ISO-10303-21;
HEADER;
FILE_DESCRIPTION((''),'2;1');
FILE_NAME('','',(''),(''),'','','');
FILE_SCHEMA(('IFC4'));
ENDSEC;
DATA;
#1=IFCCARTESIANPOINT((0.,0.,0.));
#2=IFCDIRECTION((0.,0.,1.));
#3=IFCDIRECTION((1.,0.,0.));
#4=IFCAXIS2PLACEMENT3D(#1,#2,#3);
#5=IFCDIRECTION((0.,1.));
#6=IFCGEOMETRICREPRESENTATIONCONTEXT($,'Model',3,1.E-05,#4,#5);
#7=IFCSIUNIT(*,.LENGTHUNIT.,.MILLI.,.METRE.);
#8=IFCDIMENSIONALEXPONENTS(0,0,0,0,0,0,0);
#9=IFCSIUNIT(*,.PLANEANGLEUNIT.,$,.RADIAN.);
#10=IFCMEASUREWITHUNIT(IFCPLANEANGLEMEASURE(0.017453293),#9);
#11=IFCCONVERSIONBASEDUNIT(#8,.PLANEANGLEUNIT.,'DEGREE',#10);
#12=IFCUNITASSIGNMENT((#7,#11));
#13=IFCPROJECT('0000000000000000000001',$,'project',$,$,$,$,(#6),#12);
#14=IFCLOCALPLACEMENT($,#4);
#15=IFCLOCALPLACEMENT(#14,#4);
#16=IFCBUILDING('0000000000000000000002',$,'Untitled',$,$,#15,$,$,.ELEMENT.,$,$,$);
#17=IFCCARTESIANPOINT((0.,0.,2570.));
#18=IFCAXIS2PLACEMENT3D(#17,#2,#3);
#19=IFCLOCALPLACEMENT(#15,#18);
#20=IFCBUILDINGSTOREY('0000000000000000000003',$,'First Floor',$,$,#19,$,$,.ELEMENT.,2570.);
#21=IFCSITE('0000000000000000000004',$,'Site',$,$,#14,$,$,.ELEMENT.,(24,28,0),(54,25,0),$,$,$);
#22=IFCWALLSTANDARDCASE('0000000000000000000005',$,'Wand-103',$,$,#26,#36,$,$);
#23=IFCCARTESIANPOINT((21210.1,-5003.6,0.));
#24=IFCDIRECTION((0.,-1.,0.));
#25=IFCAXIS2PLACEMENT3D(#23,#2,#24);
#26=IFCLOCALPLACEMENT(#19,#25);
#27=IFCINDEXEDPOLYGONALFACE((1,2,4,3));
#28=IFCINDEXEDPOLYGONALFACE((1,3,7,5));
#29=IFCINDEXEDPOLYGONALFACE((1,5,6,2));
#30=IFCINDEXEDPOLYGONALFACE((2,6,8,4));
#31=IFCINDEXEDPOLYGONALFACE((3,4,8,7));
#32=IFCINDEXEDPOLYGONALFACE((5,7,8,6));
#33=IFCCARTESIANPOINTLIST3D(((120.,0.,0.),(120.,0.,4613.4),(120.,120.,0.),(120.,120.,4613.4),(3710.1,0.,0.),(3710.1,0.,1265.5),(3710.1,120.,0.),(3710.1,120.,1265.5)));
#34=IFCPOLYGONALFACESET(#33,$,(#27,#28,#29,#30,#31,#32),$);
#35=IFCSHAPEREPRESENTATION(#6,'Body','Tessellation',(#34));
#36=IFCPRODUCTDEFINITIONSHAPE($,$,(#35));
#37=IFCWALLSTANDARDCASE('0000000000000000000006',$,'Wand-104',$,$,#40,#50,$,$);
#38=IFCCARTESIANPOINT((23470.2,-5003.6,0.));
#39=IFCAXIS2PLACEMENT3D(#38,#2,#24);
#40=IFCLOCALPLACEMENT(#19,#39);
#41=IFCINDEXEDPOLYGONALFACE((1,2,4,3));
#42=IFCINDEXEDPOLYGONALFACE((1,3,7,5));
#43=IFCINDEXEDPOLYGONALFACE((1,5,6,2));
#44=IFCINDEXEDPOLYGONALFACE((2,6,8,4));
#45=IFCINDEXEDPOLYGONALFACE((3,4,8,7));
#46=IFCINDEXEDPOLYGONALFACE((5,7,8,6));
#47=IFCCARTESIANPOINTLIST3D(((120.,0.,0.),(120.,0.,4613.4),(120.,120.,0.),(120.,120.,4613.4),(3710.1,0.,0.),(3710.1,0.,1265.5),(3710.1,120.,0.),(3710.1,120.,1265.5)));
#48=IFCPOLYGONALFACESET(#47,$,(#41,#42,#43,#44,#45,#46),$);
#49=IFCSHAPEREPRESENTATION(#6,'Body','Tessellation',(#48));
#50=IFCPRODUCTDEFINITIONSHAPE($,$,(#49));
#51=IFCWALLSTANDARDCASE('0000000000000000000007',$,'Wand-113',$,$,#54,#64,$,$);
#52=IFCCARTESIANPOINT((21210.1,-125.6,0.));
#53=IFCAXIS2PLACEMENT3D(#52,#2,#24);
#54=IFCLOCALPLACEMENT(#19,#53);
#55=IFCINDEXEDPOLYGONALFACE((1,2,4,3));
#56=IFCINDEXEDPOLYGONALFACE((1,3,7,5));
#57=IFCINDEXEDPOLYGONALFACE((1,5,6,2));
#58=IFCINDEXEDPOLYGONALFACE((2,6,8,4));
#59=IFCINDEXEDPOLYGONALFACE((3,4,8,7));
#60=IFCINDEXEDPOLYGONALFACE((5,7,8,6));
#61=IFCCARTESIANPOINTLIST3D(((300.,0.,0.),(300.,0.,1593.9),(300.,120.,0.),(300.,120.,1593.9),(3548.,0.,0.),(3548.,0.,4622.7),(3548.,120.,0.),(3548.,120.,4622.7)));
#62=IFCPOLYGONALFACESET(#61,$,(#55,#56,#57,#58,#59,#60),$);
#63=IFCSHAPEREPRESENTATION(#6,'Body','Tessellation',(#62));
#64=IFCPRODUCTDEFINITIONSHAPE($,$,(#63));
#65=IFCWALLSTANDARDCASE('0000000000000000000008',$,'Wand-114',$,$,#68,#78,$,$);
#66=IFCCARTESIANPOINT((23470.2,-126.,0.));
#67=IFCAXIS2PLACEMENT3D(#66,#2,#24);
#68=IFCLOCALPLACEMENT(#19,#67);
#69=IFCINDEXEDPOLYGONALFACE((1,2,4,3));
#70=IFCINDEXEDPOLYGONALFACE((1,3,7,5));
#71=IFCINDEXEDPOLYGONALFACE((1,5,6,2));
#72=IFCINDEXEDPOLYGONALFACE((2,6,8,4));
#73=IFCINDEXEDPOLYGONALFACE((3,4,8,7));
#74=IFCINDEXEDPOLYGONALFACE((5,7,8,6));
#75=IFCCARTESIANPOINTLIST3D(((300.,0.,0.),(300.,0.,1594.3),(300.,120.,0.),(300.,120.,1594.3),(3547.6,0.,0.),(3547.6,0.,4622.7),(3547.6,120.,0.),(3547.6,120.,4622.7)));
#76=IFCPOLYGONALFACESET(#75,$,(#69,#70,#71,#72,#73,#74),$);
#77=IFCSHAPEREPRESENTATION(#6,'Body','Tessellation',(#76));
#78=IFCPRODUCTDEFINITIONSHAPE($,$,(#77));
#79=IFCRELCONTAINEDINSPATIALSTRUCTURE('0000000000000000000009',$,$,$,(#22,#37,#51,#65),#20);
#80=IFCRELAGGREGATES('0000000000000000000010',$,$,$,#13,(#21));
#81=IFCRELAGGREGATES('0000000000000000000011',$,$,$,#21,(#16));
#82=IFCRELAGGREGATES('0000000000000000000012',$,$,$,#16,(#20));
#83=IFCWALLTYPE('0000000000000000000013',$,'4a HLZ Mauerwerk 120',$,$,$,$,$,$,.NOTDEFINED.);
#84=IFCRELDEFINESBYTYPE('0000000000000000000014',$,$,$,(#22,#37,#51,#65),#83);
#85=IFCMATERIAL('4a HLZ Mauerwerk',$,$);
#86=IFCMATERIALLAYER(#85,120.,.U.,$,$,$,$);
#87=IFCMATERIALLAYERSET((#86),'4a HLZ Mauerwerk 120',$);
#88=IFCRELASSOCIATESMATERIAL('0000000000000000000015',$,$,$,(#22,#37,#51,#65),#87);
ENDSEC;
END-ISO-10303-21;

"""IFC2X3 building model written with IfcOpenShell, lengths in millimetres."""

from ifc_helpers import new_model, entity, si_unit, converted_unit, direction, frame, origin_with_axes, place, context, project, spatial, polyline, outline, extrude, clip, halfspace, material, layer, layer_set, layer_usage, type_object, element, save


model = new_model("IFC2X3")

# Units and contexts
model_context = context("Model", 3, precision=1e-05, world=origin_with_axes(), true_north=direction((0.0, 1.0)))
ifc_project = project(units=[si_unit("LENGTHUNIT", "METRE", prefix="MILLI"), converted_unit("PLANEANGLEUNIT", "DEGREE", entity("IfcPlaneAngleMeasure", 0.017453293), si_unit("PLANEANGLEUNIT", "RADIAN"), dimensions=[0, 0, 0, 0, 0, 0, 0])], contexts=[model_context])

# Site, building, storey
site_placement = place(None, origin_with_axes())
site = spatial("IfcSite", under=ifc_project, at=site_placement, Name="Site", CompositionType="ELEMENT", RefLatitude=(24, 28, 0), RefLongitude=(54, 25, 0))
building_placement = place(site_placement, origin_with_axes())
building = spatial("IfcBuilding", under=site, at=building_placement, Name="Untitled", CompositionType="ELEMENT")
storey_placement = place(building_placement, frame((0.0, 0.0, 2570.0), z_axis=(0.0, 0.0, 1.0), x_axis=(1.0, 0.0, 0.0)))
storey = spatial("IfcBuildingStorey", under=building, at=storey_placement, Name="First Floor", CompositionType="ELEMENT", Elevation=2570.0)

# Shared definitions
ifc_material = material(Name="4a HLZ Mauerwerk")

# Walls
ifc_layer_1 = layer(ifc_material, 120.0, ventilated="UNKNOWN")
ifc_layer_set_1 = layer_set([ifc_layer_1], Name="4a HLZ Mauerwerk 120")
ifc_layer_usage_1 = layer_usage(ifc_layer_set_1, "AXIS2", "POSITIVE", 0.0)
wall_type_1 = type_object("IfcWallType", Name="4a HLZ Mauerwerk 120", PredefinedType="NOTDEFINED")
wall_1_placement = place(storey_placement, frame((21210.1, -5003.6, 0.0), z_axis=(0.0, 0.0, 1.0), x_axis=(0.0, -1.0, 0.0)))
element("IfcWallStandardCase", 1, at=wall_1_placement, inside=storey, type_object=wall_type_1, material=ifc_layer_usage_1, Name="Wand-103", context=model_context, shape_type="Clipping", body=[
    clip(extrude(outline(polyline([(120.0, 0.0), (3710.1, 0.0), (3710.1, 120.0), (120.0, 120.0), (120.0, 0.0)])), origin_with_axes(), (0.0, 0.0, 1.0), 5316.0), halfspace(frame((2356.9, 0.0, 2527.4), z_axis=(-0.681998, 0.0, -0.731354), x_axis=(0.731354, 0.0, -0.681998)), True)),
])
ifc_layer_usage_2 = layer_usage(ifc_layer_set_1, "AXIS2", "POSITIVE", 0.0)
wall_2_placement = place(storey_placement, frame((23470.2, -5003.6, 0.0), z_axis=(0.0, 0.0, 1.0), x_axis=(0.0, -1.0, 0.0)))
element("IfcWallStandardCase", 2, at=wall_2_placement, inside=storey, type_object=wall_type_1, material=ifc_layer_usage_2, Name="Wand-104", context=model_context, shape_type="Clipping", body=[
    clip(extrude(outline(polyline([(120.0, 0.0), (3710.1, 0.0), (3710.1, 120.0), (120.0, 120.0), (120.0, 0.0)])), origin_with_axes(), (0.0, 0.0, 1.0), 5316.0), halfspace(frame((2356.9, 0.0, 2527.4), z_axis=(-0.681998, 0.0, -0.731354), x_axis=(0.731354, 0.0, -0.681998)), True)),
])
ifc_layer_usage_3 = layer_usage(ifc_layer_set_1, "AXIS2", "POSITIVE", 0.0)
wall_3_placement = place(storey_placement, frame((21210.1, -125.6, 0.0), z_axis=(0.0, 0.0, 1.0), x_axis=(0.0, -1.0, 0.0)))
element("IfcWallStandardCase", 3, at=wall_3_placement, inside=storey, type_object=wall_type_1, material=ifc_layer_usage_3, Name="Wand-113", context=model_context, shape_type="Clipping", body=[
    clip(extrude(outline(polyline([(300.0, 0.0), (3548.0, 0.0), (3548.0, 120.0), (300.0, 120.0), (300.0, 0.0)])), origin_with_axes(), (0.0, 0.0, 1.0), 5316.0), halfspace(frame((-655.5, 0.0, 702.9), z_axis=(0.681998, 0.0, -0.731354), x_axis=(0.731354, 0.0, 0.681998)), True)),
])
ifc_layer_usage_4 = layer_usage(ifc_layer_set_1, "AXIS2", "POSITIVE", 0.0)
wall_4_placement = place(storey_placement, frame((23470.2, -126.0, 0.0), z_axis=(0.0, 0.0, 1.0), x_axis=(0.0, -1.0, 0.0)))
element("IfcWallStandardCase", 4, at=wall_4_placement, inside=storey, type_object=wall_type_1, material=ifc_layer_usage_4, Name="Wand-114", context=model_context, shape_type="Clipping", body=[
    clip(extrude(outline(polyline([(300.0, 0.0), (3547.6, 0.0), (3547.6, 120.0), (300.0, 120.0), (300.0, 0.0)])), origin_with_axes(), (0.0, 0.0, 1.0), 5316.0), halfspace(frame((-655.7, 0.0, 703.1), z_axis=(0.681998, 0.0, -0.731354), x_axis=(0.731354, 0.0, 0.681998)), True)),
])

save(model, "model.ifc")
